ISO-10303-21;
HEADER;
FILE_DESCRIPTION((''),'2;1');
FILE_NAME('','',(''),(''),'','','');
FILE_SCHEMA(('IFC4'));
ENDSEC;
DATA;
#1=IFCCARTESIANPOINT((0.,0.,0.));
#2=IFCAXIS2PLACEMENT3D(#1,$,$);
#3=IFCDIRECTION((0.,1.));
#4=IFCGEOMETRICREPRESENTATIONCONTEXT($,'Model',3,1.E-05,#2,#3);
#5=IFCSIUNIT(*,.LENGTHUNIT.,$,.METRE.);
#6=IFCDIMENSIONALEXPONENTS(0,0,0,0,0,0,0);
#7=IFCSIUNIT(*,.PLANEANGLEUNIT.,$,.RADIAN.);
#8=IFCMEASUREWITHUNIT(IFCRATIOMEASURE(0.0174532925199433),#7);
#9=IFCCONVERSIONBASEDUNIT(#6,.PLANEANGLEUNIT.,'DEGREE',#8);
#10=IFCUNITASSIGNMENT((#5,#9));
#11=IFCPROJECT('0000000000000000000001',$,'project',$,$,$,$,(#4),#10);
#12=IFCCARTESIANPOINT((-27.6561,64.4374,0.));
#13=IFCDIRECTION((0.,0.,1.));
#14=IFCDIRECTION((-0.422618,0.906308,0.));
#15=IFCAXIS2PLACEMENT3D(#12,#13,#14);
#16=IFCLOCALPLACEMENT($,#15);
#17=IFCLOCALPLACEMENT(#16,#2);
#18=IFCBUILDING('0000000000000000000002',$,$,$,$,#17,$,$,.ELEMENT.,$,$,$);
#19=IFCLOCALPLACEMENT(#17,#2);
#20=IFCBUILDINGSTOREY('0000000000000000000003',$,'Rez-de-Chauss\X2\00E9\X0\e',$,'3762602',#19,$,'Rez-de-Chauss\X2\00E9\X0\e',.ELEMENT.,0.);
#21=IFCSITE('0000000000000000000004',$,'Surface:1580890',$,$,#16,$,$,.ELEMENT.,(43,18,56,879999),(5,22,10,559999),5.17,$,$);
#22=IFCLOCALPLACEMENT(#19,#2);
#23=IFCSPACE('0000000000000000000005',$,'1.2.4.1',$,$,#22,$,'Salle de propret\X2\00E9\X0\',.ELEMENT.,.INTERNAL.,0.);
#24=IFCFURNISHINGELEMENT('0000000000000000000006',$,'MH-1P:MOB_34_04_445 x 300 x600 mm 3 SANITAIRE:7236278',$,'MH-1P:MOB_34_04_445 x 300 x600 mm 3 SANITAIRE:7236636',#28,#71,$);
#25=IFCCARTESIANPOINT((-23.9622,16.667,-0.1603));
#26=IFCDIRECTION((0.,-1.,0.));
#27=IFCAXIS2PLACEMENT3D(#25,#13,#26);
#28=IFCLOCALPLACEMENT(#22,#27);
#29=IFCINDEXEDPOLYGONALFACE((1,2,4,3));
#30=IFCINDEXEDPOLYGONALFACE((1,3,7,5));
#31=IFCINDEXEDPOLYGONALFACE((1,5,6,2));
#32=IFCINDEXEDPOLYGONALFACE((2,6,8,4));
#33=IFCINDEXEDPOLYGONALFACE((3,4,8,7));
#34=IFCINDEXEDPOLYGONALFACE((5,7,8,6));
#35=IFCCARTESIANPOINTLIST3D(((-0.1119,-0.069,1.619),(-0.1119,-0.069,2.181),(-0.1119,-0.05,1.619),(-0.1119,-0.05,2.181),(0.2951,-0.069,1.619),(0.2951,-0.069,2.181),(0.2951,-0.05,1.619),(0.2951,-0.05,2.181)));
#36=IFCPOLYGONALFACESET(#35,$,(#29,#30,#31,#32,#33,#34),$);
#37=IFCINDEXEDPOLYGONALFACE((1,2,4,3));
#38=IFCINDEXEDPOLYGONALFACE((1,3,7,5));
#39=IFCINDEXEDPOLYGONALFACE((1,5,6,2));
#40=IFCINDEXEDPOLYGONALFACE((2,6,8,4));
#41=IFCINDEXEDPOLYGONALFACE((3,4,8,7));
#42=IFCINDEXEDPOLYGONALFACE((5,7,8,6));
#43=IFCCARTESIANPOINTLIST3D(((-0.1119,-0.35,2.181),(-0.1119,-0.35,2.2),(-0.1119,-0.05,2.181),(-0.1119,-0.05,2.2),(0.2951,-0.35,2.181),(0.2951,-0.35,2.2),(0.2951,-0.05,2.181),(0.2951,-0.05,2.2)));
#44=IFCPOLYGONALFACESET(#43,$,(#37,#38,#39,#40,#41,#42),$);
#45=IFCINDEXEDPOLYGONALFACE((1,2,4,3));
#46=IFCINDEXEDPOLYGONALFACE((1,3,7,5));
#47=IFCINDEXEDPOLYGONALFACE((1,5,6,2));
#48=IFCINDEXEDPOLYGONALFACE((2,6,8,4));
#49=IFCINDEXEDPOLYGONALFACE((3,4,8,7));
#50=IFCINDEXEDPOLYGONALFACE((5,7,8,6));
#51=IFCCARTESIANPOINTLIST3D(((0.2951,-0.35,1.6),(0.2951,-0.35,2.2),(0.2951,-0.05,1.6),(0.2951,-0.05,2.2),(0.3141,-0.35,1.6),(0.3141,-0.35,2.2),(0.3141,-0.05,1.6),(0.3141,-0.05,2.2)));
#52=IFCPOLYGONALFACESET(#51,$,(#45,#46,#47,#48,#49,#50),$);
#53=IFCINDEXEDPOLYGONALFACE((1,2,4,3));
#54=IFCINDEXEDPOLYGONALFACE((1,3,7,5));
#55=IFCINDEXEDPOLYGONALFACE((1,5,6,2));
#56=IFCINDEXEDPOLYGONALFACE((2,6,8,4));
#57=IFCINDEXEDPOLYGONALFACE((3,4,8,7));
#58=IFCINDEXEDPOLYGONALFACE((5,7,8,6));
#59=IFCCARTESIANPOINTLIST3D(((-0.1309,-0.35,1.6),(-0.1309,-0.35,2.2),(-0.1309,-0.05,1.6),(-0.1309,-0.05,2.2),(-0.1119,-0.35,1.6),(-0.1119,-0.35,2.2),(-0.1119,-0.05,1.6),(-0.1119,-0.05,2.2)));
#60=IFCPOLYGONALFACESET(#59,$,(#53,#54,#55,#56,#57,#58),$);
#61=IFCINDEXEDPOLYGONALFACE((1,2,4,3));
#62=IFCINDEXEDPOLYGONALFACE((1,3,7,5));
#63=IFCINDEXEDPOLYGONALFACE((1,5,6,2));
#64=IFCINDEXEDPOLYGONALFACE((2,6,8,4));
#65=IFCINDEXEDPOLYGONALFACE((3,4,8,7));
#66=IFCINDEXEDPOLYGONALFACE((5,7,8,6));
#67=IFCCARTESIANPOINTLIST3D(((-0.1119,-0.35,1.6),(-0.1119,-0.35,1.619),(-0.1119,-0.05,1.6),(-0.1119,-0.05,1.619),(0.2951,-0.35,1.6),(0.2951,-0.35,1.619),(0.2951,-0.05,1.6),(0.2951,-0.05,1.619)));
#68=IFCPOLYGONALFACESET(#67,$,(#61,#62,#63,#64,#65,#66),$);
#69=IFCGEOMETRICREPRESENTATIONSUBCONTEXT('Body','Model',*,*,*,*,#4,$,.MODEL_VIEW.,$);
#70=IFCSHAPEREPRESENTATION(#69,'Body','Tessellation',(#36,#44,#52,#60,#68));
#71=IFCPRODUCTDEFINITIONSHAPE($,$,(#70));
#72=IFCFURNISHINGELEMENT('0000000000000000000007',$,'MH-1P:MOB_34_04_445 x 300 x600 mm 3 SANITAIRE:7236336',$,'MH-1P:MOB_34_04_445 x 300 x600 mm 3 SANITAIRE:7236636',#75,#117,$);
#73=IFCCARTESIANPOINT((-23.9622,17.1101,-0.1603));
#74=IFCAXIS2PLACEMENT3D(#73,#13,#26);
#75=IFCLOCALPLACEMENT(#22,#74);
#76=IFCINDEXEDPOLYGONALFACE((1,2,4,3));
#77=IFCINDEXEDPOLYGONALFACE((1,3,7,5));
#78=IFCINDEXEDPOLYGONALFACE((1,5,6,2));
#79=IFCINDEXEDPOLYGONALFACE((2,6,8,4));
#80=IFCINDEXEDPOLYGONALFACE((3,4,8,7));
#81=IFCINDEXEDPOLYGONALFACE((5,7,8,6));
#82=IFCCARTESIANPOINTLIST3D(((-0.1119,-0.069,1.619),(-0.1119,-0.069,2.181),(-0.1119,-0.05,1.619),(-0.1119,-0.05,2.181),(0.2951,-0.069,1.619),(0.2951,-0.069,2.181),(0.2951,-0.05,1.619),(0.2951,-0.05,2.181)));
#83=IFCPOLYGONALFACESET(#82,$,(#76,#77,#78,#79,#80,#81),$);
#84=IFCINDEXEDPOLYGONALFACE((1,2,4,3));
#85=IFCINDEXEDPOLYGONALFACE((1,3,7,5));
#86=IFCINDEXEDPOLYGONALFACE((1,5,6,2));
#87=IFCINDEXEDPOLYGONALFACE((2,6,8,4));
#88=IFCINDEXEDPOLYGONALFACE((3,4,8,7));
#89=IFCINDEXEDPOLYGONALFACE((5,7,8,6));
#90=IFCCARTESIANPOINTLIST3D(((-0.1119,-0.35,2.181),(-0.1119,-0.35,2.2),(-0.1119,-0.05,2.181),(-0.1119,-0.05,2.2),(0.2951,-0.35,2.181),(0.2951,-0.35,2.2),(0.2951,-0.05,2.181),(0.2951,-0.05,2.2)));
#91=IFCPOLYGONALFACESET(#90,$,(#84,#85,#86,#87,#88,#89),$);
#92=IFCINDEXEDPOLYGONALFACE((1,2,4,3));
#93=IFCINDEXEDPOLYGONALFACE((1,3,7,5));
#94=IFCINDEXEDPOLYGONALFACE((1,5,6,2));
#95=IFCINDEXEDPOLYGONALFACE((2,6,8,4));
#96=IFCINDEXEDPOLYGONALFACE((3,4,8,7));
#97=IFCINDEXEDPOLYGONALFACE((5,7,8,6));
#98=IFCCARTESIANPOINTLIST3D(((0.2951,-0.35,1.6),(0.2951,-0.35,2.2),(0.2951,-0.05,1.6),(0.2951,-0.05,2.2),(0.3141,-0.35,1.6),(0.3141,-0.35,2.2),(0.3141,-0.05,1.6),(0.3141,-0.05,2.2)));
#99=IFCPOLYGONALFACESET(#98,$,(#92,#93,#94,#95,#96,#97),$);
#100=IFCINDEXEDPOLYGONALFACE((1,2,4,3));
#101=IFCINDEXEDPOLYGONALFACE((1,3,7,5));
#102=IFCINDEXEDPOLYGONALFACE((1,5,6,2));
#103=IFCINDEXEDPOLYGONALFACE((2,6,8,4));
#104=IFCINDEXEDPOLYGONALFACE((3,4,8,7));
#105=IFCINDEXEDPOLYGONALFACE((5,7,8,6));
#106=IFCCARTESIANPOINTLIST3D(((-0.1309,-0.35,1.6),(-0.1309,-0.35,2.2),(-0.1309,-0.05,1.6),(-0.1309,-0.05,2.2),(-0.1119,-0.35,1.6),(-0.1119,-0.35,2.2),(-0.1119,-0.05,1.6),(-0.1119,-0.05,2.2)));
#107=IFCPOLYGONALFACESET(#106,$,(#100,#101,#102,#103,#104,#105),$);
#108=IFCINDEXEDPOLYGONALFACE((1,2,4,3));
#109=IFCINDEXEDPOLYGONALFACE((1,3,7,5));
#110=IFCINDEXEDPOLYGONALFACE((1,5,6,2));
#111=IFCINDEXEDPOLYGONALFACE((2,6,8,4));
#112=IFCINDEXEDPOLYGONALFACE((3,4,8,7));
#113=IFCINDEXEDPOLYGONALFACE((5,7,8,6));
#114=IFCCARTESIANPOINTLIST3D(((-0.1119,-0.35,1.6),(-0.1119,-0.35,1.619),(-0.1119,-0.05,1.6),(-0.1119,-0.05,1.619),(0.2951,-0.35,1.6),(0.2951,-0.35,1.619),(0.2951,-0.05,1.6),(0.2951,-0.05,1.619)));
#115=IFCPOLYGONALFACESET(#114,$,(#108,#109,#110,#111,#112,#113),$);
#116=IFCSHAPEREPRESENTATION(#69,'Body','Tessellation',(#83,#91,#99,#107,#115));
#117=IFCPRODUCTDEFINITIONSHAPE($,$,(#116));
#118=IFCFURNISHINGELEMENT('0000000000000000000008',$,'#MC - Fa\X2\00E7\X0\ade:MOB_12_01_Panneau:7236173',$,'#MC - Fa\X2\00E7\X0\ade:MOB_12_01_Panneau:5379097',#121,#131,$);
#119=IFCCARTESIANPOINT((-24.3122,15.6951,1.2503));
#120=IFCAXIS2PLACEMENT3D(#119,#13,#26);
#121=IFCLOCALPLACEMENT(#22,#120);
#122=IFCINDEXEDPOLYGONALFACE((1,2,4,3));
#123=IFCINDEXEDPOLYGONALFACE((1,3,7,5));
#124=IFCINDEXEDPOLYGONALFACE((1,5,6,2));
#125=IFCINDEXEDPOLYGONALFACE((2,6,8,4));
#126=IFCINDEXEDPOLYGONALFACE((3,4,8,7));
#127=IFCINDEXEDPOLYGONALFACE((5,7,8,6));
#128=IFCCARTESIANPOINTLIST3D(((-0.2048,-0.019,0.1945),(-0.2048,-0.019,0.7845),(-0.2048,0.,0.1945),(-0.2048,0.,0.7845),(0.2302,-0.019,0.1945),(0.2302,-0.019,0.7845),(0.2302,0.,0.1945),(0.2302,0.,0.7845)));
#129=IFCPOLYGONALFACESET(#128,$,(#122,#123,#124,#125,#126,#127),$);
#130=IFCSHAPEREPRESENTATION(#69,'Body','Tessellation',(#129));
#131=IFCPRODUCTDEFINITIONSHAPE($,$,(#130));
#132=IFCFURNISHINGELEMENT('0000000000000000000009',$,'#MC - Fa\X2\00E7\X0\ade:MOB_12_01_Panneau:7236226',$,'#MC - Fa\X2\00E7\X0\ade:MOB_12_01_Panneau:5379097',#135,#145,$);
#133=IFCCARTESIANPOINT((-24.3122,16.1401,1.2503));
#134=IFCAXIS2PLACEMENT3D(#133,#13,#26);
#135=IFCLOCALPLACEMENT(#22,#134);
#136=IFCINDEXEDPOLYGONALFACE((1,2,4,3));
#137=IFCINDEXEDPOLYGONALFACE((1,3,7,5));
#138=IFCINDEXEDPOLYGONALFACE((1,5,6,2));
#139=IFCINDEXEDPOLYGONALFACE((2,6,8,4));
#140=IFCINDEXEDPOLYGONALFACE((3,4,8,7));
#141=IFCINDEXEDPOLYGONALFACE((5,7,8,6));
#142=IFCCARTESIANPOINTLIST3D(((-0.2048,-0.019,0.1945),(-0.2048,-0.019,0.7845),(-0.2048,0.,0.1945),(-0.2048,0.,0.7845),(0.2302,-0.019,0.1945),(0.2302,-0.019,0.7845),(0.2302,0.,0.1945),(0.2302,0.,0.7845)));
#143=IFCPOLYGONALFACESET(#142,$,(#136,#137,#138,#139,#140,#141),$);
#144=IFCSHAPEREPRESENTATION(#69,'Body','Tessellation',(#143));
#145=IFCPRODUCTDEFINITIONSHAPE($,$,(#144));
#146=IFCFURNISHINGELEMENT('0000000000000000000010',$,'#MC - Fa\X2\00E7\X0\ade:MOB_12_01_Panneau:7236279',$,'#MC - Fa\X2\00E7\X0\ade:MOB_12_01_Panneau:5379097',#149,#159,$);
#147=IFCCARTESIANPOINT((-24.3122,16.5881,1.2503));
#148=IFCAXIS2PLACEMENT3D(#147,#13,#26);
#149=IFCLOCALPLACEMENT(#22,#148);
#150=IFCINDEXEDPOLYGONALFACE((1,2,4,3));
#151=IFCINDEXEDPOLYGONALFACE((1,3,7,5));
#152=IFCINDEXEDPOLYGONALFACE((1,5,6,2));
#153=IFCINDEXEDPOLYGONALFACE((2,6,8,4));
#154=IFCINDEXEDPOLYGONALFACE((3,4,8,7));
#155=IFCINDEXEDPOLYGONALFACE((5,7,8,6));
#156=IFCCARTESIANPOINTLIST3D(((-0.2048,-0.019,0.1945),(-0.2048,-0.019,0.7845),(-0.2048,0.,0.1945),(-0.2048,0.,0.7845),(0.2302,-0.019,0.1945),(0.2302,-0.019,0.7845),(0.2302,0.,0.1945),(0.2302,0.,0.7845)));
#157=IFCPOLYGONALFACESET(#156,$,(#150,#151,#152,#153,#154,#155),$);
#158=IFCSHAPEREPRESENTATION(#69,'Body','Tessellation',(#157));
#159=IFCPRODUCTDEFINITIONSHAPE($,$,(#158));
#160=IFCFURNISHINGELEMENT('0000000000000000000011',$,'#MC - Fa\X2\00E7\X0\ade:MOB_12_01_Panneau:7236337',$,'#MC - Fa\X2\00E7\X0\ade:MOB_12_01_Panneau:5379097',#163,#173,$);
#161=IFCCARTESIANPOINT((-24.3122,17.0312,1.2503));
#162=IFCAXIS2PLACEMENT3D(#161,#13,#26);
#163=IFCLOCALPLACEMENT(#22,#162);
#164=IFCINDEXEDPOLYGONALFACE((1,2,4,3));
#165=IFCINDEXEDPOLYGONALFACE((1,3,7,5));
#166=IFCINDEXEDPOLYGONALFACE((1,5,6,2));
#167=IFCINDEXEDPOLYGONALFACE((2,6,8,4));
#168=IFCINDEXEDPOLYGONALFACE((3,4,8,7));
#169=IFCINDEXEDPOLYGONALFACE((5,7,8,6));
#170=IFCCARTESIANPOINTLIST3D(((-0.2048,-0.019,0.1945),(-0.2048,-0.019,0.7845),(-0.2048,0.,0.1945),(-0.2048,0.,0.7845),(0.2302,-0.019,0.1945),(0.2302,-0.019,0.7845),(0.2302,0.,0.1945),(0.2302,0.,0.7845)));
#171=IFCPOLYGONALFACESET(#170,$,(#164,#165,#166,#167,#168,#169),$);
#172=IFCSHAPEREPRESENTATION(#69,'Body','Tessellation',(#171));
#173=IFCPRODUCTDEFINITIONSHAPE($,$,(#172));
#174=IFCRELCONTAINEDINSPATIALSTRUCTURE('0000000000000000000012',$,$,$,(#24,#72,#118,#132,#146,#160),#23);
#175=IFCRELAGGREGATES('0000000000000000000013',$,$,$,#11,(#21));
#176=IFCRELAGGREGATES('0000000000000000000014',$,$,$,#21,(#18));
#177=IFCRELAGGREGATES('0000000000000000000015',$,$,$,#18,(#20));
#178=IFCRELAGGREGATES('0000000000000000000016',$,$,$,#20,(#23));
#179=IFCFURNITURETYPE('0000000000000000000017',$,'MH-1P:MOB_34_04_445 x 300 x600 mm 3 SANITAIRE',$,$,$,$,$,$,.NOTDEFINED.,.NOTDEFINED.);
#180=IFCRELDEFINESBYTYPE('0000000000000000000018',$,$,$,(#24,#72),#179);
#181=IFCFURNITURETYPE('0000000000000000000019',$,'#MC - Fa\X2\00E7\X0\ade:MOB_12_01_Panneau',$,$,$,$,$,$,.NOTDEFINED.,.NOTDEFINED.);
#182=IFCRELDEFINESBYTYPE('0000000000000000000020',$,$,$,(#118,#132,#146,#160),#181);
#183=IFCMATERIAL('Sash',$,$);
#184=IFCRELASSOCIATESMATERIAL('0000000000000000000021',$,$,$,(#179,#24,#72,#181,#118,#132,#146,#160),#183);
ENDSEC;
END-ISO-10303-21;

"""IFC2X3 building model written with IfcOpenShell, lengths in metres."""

from ifc_helpers import new_model, entity, si_unit, converted_unit, direction, frame, origin, origin_2d_with_axis, place, context, subcontext, project, spatial, rectangle, extrude, source, transform, mapped, material, type_object, type_shapes, element, save


model = new_model("IFC2X3")

# Units and contexts
model_context = context("Model", 3, precision=1e-05, world=origin(), true_north=direction((0.0, 1.0)))
body_context = subcontext(model_context, "Body", "Model", "MODEL_VIEW")
ifc_project = project(units=[si_unit("LENGTHUNIT", "METRE"), converted_unit("PLANEANGLEUNIT", "DEGREE", entity("IfcRatioMeasure", 0.0174532925199433), si_unit("PLANEANGLEUNIT", "RADIAN"), dimensions=[0, 0, 0, 0, 0, 0, 0])], contexts=[model_context])

# Site, building, storey
site_placement = place(None, frame((-27.6561, 64.4374, 0.0), z_axis=(0.0, 0.0, 1.0), x_axis=(-0.422618, 0.906308, 0.0)))
site = spatial("IfcSite", under=ifc_project, at=site_placement, Name="Surface:1580890", CompositionType="ELEMENT", RefLatitude=(43, 18, 56, 879999), RefLongitude=(5, 22, 10, 559999), RefElevation=5.17)
building_placement = place(site_placement, origin())
building = spatial("IfcBuilding", under=site, at=building_placement, CompositionType="ELEMENT")
storey_placement = place(building_placement, origin())
storey = spatial("IfcBuildingStorey", under=building, at=storey_placement, Name="Rez-de-Chaussée", ObjectType="3762602", LongName="Rez-de-Chaussée", CompositionType="ELEMENT", Elevation=0.0)

# Shared definitions
ifc_material_1 = material(Name="Sash")

# Shared definitions
space_placement = place(storey_placement, origin())
space = spatial("IfcSpace", under=storey, at=space_placement, Name="1.2.4.1", LongName="Salle de propreté", CompositionType="ELEMENT", InteriorOrExteriorSpace="INTERNAL", ElevationWithFlooring=0.0)

# Furnishing elements
furniture_type_1 = type_object("IfcFurnitureType", Name="MH-1P:MOB_34_04_445 x 300 x600 mm 3 SANITAIRE", material=ifc_material_1)
shared_shape_1 = source(origin(), body_context, "Body", "SweptSolid", [
    extrude(rectangle(XDim=0.019, YDim=0.407, at=origin_2d_with_axis()), frame((0.0916, -0.0595, 1.619), z_axis=(0.0, 0.0, 1.0), x_axis=(0.0, -1.0, 0.0)), (0.0, 0.0, 1.0), 0.562),
    extrude(rectangle(XDim=0.407, YDim=0.3, at=origin_2d_with_axis()), frame((0.0916, -0.2, 2.181), z_axis=(0.0, 0.0, 1.0), x_axis=(-1.0, 0.0, 0.0)), (0.0, 0.0, 1.0), 0.019),
    extrude(rectangle(XDim=0.019, YDim=0.3, at=origin_2d_with_axis()), frame((0.3046, -0.2, 1.6), z_axis=(0.0, 0.0, 1.0), x_axis=(-1.0, 0.0, 0.0)), (0.0, 0.0, 1.0), 0.6),
    extrude(rectangle(XDim=0.019, YDim=0.3, at=origin_2d_with_axis()), frame((-0.1214, -0.2, 1.6), z_axis=(0.0, 0.0, 1.0), x_axis=(-1.0, 0.0, 0.0)), (0.0, 0.0, 1.0), 0.6),
    extrude(rectangle(XDim=0.407, YDim=0.3, at=origin_2d_with_axis()), frame((0.0916, -0.2, 1.6), z_axis=(0.0, 0.0, 1.0), x_axis=(-1.0, 0.0, 0.0)), (0.0, 0.0, 1.0), 0.019),
])
type_shapes(furniture_type_1, [shared_shape_1])
for number, where, z_axis, x_axis, name in (
    (1, (-23.9622, 16.667, -0.1603), (0.0, 0.0, 1.0), (0.0, -1.0, 0.0), "MH-1P:MOB_34_04_445 x 300 x600 mm 3 SANITAIRE:7236278"),
    (2, (-23.9622, 17.1101, -0.1603), (0.0, 0.0, 1.0), (0.0, -1.0, 0.0), "MH-1P:MOB_34_04_445 x 300 x600 mm 3 SANITAIRE:7236336"),
):
    element("IfcFurnishingElement", number, at=place(space_placement, frame(where, z_axis=z_axis, x_axis=x_axis)), inside=space, type_object=furniture_type_1, material=ifc_material_1, Name=name, ObjectType="MH-1P:MOB_34_04_445 x 300 x600 mm 3 SANITAIRE:7236636", context=body_context, shape_type="MappedRepresentation", body=[
        mapped(shared_shape_1, transform((0.0, 0.0, 0.0), scale=1.0)),
    ])
furniture_type_2 = type_object("IfcFurnitureType", Name="#MC - Façade:MOB_12_01_Panneau", material=ifc_material_1)
shared_shape_2 = source(origin(), body_context, "Body", "SweptSolid", [
    extrude(rectangle(XDim=0.435, YDim=0.019, at=origin_2d_with_axis()), frame((0.0127, -0.0095, 0.1945), z_axis=(0.0, 0.0, 1.0), x_axis=(-1.0, 0.0, 0.0)), (0.0, 0.0, 1.0), 0.59),
])
type_shapes(furniture_type_2, [shared_shape_2])
for number, where, z_axis, x_axis, name in (
    (3, (-24.3122, 15.6951, 1.2503), (0.0, 0.0, 1.0), (0.0, -1.0, 0.0), "#MC - Façade:MOB_12_01_Panneau:7236173"),
    (4, (-24.3122, 16.1401, 1.2503), (0.0, 0.0, 1.0), (0.0, -1.0, 0.0), "#MC - Façade:MOB_12_01_Panneau:7236226"),
    (5, (-24.3122, 16.5881, 1.2503), (0.0, 0.0, 1.0), (0.0, -1.0, 0.0), "#MC - Façade:MOB_12_01_Panneau:7236279"),
    (6, (-24.3122, 17.0312, 1.2503), (0.0, 0.0, 1.0), (0.0, -1.0, 0.0), "#MC - Façade:MOB_12_01_Panneau:7236337"),
):
    element("IfcFurnishingElement", number, at=place(space_placement, frame(where, z_axis=z_axis, x_axis=x_axis)), inside=space, type_object=furniture_type_2, material=ifc_material_1, Name=name, ObjectType="#MC - Façade:MOB_12_01_Panneau:5379097", context=body_context, shape_type="MappedRepresentation", body=[
        mapped(shared_shape_2, transform((0.0, 0.0, 0.0), scale=1.0)),
    ])

save(model, "model.ifc")
